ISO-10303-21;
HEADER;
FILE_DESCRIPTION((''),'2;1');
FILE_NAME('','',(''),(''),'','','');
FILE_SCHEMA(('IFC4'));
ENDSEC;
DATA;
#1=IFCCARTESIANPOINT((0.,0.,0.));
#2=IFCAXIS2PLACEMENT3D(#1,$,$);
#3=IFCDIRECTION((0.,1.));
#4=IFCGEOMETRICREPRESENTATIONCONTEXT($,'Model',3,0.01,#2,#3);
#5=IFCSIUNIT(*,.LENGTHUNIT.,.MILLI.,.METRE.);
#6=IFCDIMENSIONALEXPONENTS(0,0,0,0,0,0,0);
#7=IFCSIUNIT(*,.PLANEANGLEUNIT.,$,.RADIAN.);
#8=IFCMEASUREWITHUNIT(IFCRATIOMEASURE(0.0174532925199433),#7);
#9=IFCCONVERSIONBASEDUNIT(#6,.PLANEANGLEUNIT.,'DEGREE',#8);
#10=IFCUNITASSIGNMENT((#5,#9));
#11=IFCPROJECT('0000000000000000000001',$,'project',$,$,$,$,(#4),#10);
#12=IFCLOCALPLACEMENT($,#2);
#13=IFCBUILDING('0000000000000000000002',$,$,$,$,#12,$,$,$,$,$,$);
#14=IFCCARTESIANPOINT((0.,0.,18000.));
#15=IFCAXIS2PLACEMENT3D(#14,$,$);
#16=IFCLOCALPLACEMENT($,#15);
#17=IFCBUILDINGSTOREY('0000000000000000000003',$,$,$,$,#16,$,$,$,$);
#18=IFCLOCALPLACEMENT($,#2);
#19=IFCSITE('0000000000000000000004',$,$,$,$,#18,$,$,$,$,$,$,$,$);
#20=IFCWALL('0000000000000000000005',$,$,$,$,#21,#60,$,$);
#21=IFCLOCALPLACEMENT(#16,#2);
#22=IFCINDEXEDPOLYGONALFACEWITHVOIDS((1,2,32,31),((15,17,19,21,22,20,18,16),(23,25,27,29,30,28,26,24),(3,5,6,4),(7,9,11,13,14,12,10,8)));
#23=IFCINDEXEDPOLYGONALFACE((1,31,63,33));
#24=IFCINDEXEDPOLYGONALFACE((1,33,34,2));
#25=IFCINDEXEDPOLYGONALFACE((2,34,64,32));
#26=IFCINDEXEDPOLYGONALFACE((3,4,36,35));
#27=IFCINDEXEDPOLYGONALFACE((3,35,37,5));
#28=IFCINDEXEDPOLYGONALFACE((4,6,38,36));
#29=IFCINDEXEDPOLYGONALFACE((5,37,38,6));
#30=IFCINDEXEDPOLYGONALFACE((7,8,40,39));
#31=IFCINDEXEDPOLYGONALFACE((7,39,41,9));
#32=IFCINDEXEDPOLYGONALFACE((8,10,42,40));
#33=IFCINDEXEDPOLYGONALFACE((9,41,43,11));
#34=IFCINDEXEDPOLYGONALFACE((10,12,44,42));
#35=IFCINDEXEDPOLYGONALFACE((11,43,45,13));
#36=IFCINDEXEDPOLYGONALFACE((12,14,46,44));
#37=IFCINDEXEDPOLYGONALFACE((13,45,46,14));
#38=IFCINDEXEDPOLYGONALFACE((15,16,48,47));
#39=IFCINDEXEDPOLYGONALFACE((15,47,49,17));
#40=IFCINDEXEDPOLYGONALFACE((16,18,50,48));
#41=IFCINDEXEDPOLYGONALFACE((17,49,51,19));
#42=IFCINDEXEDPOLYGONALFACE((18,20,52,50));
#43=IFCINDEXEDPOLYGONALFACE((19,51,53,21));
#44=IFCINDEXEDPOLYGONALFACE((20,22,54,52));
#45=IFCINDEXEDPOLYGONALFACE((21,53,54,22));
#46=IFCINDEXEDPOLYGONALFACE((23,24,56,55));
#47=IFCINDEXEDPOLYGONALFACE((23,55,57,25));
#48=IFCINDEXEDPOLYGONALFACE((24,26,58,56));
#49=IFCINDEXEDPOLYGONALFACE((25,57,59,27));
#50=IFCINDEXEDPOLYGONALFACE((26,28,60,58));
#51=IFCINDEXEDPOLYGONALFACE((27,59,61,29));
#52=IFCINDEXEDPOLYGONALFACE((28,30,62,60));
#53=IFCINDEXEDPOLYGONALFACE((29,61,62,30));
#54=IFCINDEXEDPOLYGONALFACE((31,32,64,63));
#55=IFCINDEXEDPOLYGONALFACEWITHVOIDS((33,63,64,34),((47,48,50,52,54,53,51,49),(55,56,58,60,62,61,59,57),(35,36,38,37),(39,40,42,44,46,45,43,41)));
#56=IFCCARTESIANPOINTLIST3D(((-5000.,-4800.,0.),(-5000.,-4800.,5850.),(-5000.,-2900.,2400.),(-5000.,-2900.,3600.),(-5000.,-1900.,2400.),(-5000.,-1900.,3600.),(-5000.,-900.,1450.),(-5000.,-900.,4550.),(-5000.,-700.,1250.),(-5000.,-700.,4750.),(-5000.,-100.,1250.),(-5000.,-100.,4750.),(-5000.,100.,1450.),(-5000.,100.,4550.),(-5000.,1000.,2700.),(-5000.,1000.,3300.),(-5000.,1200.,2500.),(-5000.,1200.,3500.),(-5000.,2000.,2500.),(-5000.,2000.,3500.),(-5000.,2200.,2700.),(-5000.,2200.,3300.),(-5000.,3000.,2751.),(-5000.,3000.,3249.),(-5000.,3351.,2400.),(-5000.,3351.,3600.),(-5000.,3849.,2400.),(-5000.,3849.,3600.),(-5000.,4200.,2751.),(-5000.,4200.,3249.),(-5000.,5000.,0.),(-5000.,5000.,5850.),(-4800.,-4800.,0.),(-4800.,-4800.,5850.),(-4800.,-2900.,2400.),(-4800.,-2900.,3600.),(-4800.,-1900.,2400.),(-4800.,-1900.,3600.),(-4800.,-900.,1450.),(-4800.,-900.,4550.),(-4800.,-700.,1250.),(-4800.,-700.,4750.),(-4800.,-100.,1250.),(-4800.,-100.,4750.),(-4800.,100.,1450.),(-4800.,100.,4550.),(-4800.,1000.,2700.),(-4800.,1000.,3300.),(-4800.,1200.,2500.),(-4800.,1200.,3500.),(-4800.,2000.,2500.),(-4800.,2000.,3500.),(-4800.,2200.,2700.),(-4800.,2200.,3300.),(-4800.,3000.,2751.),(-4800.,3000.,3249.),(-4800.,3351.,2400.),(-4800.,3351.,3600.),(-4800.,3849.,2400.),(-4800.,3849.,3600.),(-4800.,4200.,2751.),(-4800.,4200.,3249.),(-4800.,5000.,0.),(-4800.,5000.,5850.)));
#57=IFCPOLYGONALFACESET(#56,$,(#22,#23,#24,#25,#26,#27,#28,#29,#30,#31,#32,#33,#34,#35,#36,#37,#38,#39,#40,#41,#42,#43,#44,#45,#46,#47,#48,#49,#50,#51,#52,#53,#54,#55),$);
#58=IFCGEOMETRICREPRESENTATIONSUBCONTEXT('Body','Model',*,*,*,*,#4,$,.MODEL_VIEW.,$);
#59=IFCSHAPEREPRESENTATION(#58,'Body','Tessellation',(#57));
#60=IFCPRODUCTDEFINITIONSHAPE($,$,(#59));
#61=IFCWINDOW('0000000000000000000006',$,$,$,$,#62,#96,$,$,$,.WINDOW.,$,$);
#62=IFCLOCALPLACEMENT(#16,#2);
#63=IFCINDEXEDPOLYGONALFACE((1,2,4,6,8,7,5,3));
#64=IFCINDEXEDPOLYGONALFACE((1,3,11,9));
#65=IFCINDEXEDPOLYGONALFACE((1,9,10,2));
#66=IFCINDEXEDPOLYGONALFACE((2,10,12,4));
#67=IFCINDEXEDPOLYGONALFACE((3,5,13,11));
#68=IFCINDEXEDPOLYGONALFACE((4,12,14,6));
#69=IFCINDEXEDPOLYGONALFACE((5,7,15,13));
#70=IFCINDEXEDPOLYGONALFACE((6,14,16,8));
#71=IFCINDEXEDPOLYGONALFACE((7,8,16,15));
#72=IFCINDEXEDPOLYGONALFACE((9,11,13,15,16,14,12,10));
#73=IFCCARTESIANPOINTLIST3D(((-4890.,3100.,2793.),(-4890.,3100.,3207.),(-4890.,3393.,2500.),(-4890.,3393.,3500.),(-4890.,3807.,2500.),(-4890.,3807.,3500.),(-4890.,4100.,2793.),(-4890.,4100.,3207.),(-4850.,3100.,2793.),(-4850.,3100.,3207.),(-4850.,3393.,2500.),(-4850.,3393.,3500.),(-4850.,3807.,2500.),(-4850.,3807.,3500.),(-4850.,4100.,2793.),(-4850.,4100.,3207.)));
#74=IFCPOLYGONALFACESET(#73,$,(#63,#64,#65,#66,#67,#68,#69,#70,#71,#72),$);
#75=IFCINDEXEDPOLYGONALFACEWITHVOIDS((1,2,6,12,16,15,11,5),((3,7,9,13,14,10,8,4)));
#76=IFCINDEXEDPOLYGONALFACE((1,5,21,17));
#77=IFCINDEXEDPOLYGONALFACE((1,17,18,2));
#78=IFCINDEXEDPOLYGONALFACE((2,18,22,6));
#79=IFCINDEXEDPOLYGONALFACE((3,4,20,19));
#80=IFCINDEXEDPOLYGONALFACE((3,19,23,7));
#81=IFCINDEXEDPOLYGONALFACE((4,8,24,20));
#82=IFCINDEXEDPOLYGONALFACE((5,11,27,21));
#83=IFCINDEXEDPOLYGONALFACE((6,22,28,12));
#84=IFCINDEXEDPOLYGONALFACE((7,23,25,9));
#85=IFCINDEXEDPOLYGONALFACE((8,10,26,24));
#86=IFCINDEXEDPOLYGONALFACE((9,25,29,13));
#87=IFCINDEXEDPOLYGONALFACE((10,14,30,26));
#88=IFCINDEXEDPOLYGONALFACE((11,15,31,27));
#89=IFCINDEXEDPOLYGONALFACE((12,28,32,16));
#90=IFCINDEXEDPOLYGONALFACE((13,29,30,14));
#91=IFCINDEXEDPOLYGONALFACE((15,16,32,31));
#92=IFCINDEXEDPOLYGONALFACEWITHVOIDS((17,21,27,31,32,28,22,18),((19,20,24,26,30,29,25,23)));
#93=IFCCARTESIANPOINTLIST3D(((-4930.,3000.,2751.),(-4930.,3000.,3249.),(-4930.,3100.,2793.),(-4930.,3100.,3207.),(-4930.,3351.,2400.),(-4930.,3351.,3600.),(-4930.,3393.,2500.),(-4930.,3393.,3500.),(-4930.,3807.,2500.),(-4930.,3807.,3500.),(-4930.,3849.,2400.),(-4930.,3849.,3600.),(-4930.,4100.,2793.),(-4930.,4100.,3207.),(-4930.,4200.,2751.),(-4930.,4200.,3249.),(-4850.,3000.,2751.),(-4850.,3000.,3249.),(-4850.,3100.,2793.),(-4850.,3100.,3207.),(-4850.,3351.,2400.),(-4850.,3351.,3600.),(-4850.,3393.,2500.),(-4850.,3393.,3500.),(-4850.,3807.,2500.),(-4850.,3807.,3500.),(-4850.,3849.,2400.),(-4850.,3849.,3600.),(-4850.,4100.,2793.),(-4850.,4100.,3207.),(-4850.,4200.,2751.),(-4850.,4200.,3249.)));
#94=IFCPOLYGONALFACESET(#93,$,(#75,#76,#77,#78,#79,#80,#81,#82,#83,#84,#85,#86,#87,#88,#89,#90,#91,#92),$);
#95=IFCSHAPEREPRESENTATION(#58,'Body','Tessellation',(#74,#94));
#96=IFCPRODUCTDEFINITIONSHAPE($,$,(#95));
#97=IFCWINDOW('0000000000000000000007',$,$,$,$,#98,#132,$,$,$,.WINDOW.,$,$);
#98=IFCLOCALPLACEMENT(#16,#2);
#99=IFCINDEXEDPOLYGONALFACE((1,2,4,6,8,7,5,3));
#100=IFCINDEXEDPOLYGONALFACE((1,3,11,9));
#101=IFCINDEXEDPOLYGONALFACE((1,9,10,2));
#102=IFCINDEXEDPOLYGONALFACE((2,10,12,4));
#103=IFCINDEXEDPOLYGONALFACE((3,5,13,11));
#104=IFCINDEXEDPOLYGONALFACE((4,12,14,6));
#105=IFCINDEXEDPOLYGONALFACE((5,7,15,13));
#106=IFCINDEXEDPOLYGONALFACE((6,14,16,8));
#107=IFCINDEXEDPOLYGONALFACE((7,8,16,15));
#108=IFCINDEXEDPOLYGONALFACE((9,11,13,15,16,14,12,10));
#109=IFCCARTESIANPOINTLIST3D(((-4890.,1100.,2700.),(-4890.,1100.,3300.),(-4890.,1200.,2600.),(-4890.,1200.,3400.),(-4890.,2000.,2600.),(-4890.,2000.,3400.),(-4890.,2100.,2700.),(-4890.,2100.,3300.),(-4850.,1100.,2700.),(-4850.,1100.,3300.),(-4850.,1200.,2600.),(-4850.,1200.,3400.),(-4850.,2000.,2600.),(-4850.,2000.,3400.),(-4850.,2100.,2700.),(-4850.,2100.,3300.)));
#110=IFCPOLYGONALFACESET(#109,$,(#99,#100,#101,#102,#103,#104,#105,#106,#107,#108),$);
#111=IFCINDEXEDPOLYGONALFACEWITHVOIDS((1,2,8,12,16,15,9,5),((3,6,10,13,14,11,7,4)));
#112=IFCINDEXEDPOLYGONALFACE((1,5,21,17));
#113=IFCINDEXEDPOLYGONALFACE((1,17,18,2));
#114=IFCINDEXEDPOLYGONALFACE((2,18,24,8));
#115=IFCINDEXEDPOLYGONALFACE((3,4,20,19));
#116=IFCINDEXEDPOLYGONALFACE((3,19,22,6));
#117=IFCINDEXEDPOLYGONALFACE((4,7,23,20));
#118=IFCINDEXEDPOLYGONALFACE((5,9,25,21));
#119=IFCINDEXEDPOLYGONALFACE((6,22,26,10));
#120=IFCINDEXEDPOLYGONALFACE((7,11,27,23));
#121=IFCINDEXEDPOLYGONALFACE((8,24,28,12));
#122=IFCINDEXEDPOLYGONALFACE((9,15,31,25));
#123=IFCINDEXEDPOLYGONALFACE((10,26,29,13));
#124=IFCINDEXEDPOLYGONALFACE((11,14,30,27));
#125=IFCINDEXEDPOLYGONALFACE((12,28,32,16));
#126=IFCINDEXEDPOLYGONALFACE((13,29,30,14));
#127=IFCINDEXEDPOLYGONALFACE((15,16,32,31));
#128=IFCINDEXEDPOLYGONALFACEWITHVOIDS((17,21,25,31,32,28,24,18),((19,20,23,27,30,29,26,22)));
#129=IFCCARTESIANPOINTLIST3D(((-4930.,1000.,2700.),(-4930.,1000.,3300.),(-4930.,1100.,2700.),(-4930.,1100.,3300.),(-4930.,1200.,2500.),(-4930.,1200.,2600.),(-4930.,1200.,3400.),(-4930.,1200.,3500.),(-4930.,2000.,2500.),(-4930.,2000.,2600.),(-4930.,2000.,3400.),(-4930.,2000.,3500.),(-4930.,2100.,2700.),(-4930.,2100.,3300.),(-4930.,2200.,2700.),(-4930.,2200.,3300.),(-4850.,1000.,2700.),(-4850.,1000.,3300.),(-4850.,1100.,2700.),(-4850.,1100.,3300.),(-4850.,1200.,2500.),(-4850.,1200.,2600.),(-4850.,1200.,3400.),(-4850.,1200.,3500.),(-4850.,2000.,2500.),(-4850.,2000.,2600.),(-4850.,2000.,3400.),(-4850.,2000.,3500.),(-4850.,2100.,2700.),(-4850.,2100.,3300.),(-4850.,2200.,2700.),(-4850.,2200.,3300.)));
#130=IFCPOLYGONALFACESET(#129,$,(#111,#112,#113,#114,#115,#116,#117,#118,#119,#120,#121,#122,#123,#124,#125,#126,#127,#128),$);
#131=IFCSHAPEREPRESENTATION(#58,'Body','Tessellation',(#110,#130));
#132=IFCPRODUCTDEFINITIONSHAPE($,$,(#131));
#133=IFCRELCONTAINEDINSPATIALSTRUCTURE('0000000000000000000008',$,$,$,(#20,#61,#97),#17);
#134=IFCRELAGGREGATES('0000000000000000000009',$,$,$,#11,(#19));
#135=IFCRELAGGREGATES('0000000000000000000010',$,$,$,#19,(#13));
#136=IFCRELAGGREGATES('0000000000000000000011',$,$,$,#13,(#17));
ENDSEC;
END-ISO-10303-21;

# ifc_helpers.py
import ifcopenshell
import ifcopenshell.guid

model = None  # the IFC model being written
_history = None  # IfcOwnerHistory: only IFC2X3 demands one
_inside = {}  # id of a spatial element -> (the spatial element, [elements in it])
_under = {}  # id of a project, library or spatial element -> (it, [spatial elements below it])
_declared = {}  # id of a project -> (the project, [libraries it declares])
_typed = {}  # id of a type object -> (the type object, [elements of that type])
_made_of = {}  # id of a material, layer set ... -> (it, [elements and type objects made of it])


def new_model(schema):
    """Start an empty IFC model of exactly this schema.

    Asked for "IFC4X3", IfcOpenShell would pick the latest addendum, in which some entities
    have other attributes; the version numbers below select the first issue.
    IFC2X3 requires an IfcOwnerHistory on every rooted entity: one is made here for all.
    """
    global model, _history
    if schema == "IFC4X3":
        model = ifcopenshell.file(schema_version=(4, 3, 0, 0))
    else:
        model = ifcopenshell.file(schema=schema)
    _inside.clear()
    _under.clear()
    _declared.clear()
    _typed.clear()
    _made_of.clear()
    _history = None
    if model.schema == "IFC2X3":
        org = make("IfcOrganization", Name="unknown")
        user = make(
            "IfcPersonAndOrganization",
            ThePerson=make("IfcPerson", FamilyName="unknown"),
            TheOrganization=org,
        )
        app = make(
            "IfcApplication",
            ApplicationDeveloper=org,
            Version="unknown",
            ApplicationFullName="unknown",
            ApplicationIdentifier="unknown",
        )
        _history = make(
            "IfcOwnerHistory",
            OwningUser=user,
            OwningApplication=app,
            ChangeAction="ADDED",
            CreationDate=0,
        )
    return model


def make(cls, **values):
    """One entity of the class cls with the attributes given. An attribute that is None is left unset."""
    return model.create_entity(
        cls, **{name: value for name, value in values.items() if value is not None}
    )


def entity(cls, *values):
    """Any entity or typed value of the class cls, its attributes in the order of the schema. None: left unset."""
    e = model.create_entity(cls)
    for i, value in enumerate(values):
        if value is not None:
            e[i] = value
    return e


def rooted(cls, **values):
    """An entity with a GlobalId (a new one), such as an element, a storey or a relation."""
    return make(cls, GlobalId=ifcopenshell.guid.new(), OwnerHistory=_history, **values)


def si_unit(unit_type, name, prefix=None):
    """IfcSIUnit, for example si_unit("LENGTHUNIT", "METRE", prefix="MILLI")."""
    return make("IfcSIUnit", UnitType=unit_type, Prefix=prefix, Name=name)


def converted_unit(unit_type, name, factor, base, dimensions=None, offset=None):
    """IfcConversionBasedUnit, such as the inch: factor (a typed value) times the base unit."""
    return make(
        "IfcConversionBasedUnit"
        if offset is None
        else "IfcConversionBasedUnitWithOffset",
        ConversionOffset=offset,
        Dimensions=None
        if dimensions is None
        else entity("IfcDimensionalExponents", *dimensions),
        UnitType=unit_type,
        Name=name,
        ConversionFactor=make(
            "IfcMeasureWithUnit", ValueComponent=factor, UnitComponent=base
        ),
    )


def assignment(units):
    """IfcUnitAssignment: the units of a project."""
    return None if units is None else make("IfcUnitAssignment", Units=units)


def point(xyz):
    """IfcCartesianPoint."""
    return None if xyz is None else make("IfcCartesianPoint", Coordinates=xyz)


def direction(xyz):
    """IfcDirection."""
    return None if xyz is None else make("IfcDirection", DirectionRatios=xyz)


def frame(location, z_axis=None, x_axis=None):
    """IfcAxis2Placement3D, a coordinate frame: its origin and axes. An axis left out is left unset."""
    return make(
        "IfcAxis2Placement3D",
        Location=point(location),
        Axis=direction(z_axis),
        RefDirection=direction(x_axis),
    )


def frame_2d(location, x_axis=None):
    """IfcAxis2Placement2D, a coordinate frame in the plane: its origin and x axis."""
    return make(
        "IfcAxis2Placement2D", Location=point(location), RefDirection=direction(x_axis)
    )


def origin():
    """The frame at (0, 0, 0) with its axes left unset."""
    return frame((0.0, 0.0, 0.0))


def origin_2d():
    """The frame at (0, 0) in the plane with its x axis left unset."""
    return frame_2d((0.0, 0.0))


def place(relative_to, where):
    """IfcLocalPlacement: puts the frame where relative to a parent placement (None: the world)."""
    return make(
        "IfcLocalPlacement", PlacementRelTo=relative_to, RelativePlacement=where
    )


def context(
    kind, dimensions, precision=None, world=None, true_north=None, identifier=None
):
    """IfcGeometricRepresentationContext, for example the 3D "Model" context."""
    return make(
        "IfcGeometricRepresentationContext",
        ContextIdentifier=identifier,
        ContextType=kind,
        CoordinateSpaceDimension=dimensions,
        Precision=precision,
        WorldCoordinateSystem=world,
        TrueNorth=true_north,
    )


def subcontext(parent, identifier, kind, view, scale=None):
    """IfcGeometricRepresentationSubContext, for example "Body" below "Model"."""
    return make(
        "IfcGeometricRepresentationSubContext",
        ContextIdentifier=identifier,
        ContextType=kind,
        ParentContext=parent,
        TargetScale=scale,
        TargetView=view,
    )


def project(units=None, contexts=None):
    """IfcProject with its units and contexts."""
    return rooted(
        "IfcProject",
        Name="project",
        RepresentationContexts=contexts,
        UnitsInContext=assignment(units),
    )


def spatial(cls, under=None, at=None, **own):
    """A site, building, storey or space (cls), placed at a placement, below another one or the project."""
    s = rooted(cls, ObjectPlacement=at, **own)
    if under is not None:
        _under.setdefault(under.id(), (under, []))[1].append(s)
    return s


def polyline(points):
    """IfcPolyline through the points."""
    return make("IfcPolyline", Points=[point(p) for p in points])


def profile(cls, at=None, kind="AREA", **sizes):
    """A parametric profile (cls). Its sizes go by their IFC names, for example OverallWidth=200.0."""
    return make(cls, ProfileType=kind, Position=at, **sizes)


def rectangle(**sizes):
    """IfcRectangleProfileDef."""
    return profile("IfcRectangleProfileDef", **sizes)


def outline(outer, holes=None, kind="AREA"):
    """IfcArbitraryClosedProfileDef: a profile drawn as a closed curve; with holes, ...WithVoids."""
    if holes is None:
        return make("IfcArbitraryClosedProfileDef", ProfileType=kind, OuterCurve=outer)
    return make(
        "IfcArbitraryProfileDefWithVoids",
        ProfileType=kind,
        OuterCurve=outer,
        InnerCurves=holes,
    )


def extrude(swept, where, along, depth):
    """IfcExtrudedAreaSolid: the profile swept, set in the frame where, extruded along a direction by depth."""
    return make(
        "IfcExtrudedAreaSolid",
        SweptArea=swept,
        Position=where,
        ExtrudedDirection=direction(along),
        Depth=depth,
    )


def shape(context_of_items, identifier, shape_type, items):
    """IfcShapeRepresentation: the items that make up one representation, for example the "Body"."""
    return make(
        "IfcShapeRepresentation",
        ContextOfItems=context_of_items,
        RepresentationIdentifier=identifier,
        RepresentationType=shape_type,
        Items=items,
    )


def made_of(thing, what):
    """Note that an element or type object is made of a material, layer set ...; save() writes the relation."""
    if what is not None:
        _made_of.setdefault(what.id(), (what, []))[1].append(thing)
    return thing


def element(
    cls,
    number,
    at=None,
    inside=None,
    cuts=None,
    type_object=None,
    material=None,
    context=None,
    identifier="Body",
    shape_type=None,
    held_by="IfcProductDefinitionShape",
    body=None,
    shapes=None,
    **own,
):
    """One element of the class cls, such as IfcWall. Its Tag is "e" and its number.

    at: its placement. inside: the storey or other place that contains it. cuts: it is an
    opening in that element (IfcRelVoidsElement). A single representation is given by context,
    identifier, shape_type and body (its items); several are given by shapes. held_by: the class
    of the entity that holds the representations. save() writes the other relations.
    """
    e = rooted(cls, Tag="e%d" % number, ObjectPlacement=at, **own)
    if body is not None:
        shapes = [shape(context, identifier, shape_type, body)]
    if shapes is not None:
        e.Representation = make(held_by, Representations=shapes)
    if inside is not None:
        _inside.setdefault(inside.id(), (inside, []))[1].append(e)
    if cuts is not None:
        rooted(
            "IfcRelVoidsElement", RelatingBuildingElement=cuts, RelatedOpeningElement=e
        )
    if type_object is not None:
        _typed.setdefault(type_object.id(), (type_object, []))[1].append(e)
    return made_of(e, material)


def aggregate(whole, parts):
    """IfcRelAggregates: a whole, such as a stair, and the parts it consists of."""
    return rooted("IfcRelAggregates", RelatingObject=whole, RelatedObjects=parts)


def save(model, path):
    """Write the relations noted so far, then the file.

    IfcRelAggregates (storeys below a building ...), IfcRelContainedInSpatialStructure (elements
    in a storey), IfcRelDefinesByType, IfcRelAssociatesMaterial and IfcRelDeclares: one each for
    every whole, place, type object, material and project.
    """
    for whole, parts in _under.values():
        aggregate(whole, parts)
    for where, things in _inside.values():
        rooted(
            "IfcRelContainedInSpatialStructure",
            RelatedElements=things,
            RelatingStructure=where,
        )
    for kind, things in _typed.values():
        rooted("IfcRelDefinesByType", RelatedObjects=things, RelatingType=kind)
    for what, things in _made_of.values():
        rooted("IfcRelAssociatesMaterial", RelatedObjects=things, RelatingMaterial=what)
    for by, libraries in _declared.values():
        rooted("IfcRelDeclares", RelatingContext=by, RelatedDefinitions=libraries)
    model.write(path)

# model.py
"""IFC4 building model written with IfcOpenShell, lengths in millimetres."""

from ifc_helpers import new_model, entity, si_unit, converted_unit, direction, frame, origin, origin_2d, place, context, subcontext, project, spatial, polyline, rectangle, outline, extrude, element, save


model = new_model("IFC4")

# Units and contexts
model_context = context("Model", 3, precision=0.01, world=origin(), true_north=direction((0.0, 1.0)))
body_context = subcontext(model_context, "Body", "Model", "MODEL_VIEW")
ifc_project = project(units=[si_unit("LENGTHUNIT", "METRE", prefix="MILLI"), converted_unit("PLANEANGLEUNIT", "DEGREE", entity("IfcRatioMeasure", 0.0174532925199433), si_unit("PLANEANGLEUNIT", "RADIAN"), dimensions=[0, 0, 0, 0, 0, 0, 0])], contexts=[model_context])

# Site, building, storey
site_placement = place(None, origin())
site = spatial("IfcSite", under=ifc_project, at=site_placement)
building_placement = place(None, origin())
building = spatial("IfcBuilding", under=site, at=building_placement)
storey_placement = place(None, frame((0.0, 0.0, 18000.0)))
storey = spatial("IfcBuildingStorey", under=building, at=storey_placement)

# Shared definitions
cartesian_point_1 = entity("IfcCartesianPoint", [-500.0, -207.0])
shared_polyline_1 = entity("IfcPolyline", [cartesian_point_1, entity("IfcCartesianPoint", [-500.0, 207.0]), entity("IfcCartesianPoint", [-207.0, 500.0]), entity("IfcCartesianPoint", [207.0, 500.0]), entity("IfcCartesianPoint", [500.0, 207.0]), entity("IfcCartesianPoint", [500.0, -207.0]), entity("IfcCartesianPoint", [207.0, -500.0]), entity("IfcCartesianPoint", [-207.0, -500.0]), cartesian_point_1])
cartesian_point_2 = entity("IfcCartesianPoint", [-500.0, -300.0])
shared_polyline_2 = entity("IfcPolyline", [cartesian_point_2, entity("IfcCartesianPoint", [-500.0, 300.0]), entity("IfcCartesianPoint", [-400.0, 400.0]), entity("IfcCartesianPoint", [400.0, 400.0]), entity("IfcCartesianPoint", [500.0, 300.0]), entity("IfcCartesianPoint", [500.0, -300.0]), entity("IfcCartesianPoint", [400.0, -400.0]), entity("IfcCartesianPoint", [-400.0, -400.0]), cartesian_point_2])

# Wall, openings
wall_1_placement = place(storey_placement, frame((-4900.0, 100.0, 0.0), z_axis=(0.0, 0.0, 1.0), x_axis=(0.0, -1.0, 0.0)))
wall_1 = element("IfcWall", 1, at=wall_1_placement, inside=storey, context=body_context, shape_type="SweptSolid", body=[
    extrude(rectangle(XDim=9800.0, YDim=200.0, at=origin_2d()), origin(), (0.0, 0.0, 1.0), 5850.0),
])
window_1_placement = place(wall_1_placement, frame((-3500.0, 50.0, 3000.0)))
opening_1_placement = place(window_1_placement, frame((0.0, 50.0, 0.0)))
element("IfcOpeningElement", 2, at=opening_1_placement, cuts=wall_1, context=body_context, shape_type="SweptSolid", body=[
    extrude(outline(polyline([(-600.0, -249.0), (-600.0, 249.0), (-249.0, 600.0), (249.0, 600.0), (600.0, 249.0), (600.0, -249.0), (249.0, -600.0), (-249.0, -600.0), (-600.0, -249.0)])), frame((0.0, 0.0, 0.0), z_axis=(0.0, -1.0, 0.0), x_axis=(1.0, 0.0, 0.0)), (0.0, 0.0, 1.0), 200.0),
])
window_2_placement = place(wall_1_placement, frame((-1500.0, 50.0, 3000.0)))
opening_2_placement = place(window_2_placement, frame((0.0, 50.0, 0.0)))
element("IfcOpeningElement", 3, at=opening_2_placement, cuts=wall_1, context=body_context, shape_type="SweptSolid", body=[
    extrude(outline(polyline([(-600.0, -300.0), (-600.0, 300.0), (-400.0, 500.0), (400.0, 500.0), (600.0, 300.0), (600.0, -300.0), (400.0, -500.0), (-400.0, -500.0), (-600.0, -300.0)])), frame((0.0, 0.0, 0.0), z_axis=(0.0, -1.0, 0.0), x_axis=(1.0, 0.0, 0.0)), (0.0, 0.0, 1.0), 200.0),
])
window_3_placement = place(wall_1_placement, frame((500.0, 50.0, 3000.0)))
opening_3_placement = place(window_3_placement, frame((0.0, 50.0, 0.0)))
element("IfcOpeningElement", 4, at=opening_3_placement, cuts=wall_1, context=body_context, shape_type="SweptSolid", body=[
    extrude(outline(polyline([(-500.0, -1550.0), (-500.0, 1550.0), (-300.0, 1750.0), (300.0, 1750.0), (500.0, 1550.0), (500.0, -1550.0), (300.0, -1750.0), (-300.0, -1750.0), (-500.0, -1550.0)])), frame((0.0, 0.0, 0.0), z_axis=(0.0, -1.0, 0.0), x_axis=(1.0, 0.0, 0.0)), (0.0, 0.0, 1.0), 200.0),
])
window_4_placement = place(wall_1_placement, frame((2500.0, 50.0, 3000.0)))
opening_4_placement = place(window_4_placement, frame((0.0, 50.0, 0.0)))
element("IfcOpeningElement", 5, at=opening_4_placement, cuts=wall_1, context=body_context, shape_type="SweptSolid", body=[
    extrude(outline(polyline([(-500.0, -600.0), (-500.0, 600.0), (-500.0, 600.0), (500.0, 600.0), (500.0, 600.0), (500.0, -600.0), (500.0, -600.0), (-500.0, -600.0), (-500.0, -600.0)])), frame((0.0, 0.0, 0.0), z_axis=(0.0, -1.0, 0.0), x_axis=(1.0, 0.0, 0.0)), (0.0, 0.0, 1.0), 200.0),
])

# Windows
cartesian_point_3 = entity("IfcCartesianPoint", [-600.0, -249.0])
element("IfcWindow", 6, at=window_1_placement, inside=storey, PredefinedType="WINDOW", context=body_context, shape_type="SweptSolid", body=[
    entity("IfcExtrudedAreaSolid", entity("IfcArbitraryClosedProfileDef", "AREA", None, shared_polyline_1), entity("IfcAxis2Placement3D", entity("IfcCartesianPoint", [0.0, 0.0, 0.0]), entity("IfcDirection", [0.0, -1.0, 0.0]), entity("IfcDirection", [1.0, 0.0, 0.0])), entity("IfcDirection", [0.0, 0.0, 1.0]), 40.0),
    entity("IfcExtrudedAreaSolid", entity("IfcArbitraryProfileDefWithVoids", "AREA", None, entity("IfcPolyline", [cartesian_point_3, entity("IfcCartesianPoint", [-600.0, 249.0]), entity("IfcCartesianPoint", [-249.0, 600.0]), entity("IfcCartesianPoint", [249.0, 600.0]), entity("IfcCartesianPoint", [600.0, 249.0]), entity("IfcCartesianPoint", [600.0, -249.0]), entity("IfcCartesianPoint", [249.0, -600.0]), entity("IfcCartesianPoint", [-249.0, -600.0]), cartesian_point_3]), [shared_polyline_1]), entity("IfcAxis2Placement3D", entity("IfcCartesianPoint", [0.0, 0.0, 0.0]), entity("IfcDirection", [0.0, -1.0, 0.0]), entity("IfcDirection", [1.0, 0.0, 0.0])), entity("IfcDirection", [0.0, 0.0, 1.0]), 80.0),
])
cartesian_point_4 = entity("IfcCartesianPoint", [-600.0, -300.0])
element("IfcWindow", 7, at=window_2_placement, inside=storey, PredefinedType="WINDOW", context=body_context, shape_type="SweptSolid", body=[
    entity("IfcExtrudedAreaSolid", entity("IfcArbitraryClosedProfileDef", "AREA", None, shared_polyline_2), entity("IfcAxis2Placement3D", entity("IfcCartesianPoint", [0.0, 0.0, 0.0]), entity("IfcDirection", [0.0, -1.0, 0.0]), entity("IfcDirection", [1.0, 0.0, 0.0])), entity("IfcDirection", [0.0, 0.0, 1.0]), 40.0),
    entity("IfcExtrudedAreaSolid", entity("IfcArbitraryProfileDefWithVoids", "AREA", None, entity("IfcPolyline", [cartesian_point_4, entity("IfcCartesianPoint", [-600.0, 300.0]), entity("IfcCartesianPoint", [-400.0, 500.0]), entity("IfcCartesianPoint", [400.0, 500.0]), entity("IfcCartesianPoint", [600.0, 300.0]), entity("IfcCartesianPoint", [600.0, -300.0]), entity("IfcCartesianPoint", [400.0, -500.0]), entity("IfcCartesianPoint", [-400.0, -500.0]), cartesian_point_4]), [shared_polyline_2]), entity("IfcAxis2Placement3D", entity("IfcCartesianPoint", [0.0, 0.0, 0.0]), entity("IfcDirection", [0.0, -1.0, 0.0]), entity("IfcDirection", [1.0, 0.0, 0.0])), entity("IfcDirection", [0.0, 0.0, 1.0]), 80.0),
])

save(model, "model.ifc")
